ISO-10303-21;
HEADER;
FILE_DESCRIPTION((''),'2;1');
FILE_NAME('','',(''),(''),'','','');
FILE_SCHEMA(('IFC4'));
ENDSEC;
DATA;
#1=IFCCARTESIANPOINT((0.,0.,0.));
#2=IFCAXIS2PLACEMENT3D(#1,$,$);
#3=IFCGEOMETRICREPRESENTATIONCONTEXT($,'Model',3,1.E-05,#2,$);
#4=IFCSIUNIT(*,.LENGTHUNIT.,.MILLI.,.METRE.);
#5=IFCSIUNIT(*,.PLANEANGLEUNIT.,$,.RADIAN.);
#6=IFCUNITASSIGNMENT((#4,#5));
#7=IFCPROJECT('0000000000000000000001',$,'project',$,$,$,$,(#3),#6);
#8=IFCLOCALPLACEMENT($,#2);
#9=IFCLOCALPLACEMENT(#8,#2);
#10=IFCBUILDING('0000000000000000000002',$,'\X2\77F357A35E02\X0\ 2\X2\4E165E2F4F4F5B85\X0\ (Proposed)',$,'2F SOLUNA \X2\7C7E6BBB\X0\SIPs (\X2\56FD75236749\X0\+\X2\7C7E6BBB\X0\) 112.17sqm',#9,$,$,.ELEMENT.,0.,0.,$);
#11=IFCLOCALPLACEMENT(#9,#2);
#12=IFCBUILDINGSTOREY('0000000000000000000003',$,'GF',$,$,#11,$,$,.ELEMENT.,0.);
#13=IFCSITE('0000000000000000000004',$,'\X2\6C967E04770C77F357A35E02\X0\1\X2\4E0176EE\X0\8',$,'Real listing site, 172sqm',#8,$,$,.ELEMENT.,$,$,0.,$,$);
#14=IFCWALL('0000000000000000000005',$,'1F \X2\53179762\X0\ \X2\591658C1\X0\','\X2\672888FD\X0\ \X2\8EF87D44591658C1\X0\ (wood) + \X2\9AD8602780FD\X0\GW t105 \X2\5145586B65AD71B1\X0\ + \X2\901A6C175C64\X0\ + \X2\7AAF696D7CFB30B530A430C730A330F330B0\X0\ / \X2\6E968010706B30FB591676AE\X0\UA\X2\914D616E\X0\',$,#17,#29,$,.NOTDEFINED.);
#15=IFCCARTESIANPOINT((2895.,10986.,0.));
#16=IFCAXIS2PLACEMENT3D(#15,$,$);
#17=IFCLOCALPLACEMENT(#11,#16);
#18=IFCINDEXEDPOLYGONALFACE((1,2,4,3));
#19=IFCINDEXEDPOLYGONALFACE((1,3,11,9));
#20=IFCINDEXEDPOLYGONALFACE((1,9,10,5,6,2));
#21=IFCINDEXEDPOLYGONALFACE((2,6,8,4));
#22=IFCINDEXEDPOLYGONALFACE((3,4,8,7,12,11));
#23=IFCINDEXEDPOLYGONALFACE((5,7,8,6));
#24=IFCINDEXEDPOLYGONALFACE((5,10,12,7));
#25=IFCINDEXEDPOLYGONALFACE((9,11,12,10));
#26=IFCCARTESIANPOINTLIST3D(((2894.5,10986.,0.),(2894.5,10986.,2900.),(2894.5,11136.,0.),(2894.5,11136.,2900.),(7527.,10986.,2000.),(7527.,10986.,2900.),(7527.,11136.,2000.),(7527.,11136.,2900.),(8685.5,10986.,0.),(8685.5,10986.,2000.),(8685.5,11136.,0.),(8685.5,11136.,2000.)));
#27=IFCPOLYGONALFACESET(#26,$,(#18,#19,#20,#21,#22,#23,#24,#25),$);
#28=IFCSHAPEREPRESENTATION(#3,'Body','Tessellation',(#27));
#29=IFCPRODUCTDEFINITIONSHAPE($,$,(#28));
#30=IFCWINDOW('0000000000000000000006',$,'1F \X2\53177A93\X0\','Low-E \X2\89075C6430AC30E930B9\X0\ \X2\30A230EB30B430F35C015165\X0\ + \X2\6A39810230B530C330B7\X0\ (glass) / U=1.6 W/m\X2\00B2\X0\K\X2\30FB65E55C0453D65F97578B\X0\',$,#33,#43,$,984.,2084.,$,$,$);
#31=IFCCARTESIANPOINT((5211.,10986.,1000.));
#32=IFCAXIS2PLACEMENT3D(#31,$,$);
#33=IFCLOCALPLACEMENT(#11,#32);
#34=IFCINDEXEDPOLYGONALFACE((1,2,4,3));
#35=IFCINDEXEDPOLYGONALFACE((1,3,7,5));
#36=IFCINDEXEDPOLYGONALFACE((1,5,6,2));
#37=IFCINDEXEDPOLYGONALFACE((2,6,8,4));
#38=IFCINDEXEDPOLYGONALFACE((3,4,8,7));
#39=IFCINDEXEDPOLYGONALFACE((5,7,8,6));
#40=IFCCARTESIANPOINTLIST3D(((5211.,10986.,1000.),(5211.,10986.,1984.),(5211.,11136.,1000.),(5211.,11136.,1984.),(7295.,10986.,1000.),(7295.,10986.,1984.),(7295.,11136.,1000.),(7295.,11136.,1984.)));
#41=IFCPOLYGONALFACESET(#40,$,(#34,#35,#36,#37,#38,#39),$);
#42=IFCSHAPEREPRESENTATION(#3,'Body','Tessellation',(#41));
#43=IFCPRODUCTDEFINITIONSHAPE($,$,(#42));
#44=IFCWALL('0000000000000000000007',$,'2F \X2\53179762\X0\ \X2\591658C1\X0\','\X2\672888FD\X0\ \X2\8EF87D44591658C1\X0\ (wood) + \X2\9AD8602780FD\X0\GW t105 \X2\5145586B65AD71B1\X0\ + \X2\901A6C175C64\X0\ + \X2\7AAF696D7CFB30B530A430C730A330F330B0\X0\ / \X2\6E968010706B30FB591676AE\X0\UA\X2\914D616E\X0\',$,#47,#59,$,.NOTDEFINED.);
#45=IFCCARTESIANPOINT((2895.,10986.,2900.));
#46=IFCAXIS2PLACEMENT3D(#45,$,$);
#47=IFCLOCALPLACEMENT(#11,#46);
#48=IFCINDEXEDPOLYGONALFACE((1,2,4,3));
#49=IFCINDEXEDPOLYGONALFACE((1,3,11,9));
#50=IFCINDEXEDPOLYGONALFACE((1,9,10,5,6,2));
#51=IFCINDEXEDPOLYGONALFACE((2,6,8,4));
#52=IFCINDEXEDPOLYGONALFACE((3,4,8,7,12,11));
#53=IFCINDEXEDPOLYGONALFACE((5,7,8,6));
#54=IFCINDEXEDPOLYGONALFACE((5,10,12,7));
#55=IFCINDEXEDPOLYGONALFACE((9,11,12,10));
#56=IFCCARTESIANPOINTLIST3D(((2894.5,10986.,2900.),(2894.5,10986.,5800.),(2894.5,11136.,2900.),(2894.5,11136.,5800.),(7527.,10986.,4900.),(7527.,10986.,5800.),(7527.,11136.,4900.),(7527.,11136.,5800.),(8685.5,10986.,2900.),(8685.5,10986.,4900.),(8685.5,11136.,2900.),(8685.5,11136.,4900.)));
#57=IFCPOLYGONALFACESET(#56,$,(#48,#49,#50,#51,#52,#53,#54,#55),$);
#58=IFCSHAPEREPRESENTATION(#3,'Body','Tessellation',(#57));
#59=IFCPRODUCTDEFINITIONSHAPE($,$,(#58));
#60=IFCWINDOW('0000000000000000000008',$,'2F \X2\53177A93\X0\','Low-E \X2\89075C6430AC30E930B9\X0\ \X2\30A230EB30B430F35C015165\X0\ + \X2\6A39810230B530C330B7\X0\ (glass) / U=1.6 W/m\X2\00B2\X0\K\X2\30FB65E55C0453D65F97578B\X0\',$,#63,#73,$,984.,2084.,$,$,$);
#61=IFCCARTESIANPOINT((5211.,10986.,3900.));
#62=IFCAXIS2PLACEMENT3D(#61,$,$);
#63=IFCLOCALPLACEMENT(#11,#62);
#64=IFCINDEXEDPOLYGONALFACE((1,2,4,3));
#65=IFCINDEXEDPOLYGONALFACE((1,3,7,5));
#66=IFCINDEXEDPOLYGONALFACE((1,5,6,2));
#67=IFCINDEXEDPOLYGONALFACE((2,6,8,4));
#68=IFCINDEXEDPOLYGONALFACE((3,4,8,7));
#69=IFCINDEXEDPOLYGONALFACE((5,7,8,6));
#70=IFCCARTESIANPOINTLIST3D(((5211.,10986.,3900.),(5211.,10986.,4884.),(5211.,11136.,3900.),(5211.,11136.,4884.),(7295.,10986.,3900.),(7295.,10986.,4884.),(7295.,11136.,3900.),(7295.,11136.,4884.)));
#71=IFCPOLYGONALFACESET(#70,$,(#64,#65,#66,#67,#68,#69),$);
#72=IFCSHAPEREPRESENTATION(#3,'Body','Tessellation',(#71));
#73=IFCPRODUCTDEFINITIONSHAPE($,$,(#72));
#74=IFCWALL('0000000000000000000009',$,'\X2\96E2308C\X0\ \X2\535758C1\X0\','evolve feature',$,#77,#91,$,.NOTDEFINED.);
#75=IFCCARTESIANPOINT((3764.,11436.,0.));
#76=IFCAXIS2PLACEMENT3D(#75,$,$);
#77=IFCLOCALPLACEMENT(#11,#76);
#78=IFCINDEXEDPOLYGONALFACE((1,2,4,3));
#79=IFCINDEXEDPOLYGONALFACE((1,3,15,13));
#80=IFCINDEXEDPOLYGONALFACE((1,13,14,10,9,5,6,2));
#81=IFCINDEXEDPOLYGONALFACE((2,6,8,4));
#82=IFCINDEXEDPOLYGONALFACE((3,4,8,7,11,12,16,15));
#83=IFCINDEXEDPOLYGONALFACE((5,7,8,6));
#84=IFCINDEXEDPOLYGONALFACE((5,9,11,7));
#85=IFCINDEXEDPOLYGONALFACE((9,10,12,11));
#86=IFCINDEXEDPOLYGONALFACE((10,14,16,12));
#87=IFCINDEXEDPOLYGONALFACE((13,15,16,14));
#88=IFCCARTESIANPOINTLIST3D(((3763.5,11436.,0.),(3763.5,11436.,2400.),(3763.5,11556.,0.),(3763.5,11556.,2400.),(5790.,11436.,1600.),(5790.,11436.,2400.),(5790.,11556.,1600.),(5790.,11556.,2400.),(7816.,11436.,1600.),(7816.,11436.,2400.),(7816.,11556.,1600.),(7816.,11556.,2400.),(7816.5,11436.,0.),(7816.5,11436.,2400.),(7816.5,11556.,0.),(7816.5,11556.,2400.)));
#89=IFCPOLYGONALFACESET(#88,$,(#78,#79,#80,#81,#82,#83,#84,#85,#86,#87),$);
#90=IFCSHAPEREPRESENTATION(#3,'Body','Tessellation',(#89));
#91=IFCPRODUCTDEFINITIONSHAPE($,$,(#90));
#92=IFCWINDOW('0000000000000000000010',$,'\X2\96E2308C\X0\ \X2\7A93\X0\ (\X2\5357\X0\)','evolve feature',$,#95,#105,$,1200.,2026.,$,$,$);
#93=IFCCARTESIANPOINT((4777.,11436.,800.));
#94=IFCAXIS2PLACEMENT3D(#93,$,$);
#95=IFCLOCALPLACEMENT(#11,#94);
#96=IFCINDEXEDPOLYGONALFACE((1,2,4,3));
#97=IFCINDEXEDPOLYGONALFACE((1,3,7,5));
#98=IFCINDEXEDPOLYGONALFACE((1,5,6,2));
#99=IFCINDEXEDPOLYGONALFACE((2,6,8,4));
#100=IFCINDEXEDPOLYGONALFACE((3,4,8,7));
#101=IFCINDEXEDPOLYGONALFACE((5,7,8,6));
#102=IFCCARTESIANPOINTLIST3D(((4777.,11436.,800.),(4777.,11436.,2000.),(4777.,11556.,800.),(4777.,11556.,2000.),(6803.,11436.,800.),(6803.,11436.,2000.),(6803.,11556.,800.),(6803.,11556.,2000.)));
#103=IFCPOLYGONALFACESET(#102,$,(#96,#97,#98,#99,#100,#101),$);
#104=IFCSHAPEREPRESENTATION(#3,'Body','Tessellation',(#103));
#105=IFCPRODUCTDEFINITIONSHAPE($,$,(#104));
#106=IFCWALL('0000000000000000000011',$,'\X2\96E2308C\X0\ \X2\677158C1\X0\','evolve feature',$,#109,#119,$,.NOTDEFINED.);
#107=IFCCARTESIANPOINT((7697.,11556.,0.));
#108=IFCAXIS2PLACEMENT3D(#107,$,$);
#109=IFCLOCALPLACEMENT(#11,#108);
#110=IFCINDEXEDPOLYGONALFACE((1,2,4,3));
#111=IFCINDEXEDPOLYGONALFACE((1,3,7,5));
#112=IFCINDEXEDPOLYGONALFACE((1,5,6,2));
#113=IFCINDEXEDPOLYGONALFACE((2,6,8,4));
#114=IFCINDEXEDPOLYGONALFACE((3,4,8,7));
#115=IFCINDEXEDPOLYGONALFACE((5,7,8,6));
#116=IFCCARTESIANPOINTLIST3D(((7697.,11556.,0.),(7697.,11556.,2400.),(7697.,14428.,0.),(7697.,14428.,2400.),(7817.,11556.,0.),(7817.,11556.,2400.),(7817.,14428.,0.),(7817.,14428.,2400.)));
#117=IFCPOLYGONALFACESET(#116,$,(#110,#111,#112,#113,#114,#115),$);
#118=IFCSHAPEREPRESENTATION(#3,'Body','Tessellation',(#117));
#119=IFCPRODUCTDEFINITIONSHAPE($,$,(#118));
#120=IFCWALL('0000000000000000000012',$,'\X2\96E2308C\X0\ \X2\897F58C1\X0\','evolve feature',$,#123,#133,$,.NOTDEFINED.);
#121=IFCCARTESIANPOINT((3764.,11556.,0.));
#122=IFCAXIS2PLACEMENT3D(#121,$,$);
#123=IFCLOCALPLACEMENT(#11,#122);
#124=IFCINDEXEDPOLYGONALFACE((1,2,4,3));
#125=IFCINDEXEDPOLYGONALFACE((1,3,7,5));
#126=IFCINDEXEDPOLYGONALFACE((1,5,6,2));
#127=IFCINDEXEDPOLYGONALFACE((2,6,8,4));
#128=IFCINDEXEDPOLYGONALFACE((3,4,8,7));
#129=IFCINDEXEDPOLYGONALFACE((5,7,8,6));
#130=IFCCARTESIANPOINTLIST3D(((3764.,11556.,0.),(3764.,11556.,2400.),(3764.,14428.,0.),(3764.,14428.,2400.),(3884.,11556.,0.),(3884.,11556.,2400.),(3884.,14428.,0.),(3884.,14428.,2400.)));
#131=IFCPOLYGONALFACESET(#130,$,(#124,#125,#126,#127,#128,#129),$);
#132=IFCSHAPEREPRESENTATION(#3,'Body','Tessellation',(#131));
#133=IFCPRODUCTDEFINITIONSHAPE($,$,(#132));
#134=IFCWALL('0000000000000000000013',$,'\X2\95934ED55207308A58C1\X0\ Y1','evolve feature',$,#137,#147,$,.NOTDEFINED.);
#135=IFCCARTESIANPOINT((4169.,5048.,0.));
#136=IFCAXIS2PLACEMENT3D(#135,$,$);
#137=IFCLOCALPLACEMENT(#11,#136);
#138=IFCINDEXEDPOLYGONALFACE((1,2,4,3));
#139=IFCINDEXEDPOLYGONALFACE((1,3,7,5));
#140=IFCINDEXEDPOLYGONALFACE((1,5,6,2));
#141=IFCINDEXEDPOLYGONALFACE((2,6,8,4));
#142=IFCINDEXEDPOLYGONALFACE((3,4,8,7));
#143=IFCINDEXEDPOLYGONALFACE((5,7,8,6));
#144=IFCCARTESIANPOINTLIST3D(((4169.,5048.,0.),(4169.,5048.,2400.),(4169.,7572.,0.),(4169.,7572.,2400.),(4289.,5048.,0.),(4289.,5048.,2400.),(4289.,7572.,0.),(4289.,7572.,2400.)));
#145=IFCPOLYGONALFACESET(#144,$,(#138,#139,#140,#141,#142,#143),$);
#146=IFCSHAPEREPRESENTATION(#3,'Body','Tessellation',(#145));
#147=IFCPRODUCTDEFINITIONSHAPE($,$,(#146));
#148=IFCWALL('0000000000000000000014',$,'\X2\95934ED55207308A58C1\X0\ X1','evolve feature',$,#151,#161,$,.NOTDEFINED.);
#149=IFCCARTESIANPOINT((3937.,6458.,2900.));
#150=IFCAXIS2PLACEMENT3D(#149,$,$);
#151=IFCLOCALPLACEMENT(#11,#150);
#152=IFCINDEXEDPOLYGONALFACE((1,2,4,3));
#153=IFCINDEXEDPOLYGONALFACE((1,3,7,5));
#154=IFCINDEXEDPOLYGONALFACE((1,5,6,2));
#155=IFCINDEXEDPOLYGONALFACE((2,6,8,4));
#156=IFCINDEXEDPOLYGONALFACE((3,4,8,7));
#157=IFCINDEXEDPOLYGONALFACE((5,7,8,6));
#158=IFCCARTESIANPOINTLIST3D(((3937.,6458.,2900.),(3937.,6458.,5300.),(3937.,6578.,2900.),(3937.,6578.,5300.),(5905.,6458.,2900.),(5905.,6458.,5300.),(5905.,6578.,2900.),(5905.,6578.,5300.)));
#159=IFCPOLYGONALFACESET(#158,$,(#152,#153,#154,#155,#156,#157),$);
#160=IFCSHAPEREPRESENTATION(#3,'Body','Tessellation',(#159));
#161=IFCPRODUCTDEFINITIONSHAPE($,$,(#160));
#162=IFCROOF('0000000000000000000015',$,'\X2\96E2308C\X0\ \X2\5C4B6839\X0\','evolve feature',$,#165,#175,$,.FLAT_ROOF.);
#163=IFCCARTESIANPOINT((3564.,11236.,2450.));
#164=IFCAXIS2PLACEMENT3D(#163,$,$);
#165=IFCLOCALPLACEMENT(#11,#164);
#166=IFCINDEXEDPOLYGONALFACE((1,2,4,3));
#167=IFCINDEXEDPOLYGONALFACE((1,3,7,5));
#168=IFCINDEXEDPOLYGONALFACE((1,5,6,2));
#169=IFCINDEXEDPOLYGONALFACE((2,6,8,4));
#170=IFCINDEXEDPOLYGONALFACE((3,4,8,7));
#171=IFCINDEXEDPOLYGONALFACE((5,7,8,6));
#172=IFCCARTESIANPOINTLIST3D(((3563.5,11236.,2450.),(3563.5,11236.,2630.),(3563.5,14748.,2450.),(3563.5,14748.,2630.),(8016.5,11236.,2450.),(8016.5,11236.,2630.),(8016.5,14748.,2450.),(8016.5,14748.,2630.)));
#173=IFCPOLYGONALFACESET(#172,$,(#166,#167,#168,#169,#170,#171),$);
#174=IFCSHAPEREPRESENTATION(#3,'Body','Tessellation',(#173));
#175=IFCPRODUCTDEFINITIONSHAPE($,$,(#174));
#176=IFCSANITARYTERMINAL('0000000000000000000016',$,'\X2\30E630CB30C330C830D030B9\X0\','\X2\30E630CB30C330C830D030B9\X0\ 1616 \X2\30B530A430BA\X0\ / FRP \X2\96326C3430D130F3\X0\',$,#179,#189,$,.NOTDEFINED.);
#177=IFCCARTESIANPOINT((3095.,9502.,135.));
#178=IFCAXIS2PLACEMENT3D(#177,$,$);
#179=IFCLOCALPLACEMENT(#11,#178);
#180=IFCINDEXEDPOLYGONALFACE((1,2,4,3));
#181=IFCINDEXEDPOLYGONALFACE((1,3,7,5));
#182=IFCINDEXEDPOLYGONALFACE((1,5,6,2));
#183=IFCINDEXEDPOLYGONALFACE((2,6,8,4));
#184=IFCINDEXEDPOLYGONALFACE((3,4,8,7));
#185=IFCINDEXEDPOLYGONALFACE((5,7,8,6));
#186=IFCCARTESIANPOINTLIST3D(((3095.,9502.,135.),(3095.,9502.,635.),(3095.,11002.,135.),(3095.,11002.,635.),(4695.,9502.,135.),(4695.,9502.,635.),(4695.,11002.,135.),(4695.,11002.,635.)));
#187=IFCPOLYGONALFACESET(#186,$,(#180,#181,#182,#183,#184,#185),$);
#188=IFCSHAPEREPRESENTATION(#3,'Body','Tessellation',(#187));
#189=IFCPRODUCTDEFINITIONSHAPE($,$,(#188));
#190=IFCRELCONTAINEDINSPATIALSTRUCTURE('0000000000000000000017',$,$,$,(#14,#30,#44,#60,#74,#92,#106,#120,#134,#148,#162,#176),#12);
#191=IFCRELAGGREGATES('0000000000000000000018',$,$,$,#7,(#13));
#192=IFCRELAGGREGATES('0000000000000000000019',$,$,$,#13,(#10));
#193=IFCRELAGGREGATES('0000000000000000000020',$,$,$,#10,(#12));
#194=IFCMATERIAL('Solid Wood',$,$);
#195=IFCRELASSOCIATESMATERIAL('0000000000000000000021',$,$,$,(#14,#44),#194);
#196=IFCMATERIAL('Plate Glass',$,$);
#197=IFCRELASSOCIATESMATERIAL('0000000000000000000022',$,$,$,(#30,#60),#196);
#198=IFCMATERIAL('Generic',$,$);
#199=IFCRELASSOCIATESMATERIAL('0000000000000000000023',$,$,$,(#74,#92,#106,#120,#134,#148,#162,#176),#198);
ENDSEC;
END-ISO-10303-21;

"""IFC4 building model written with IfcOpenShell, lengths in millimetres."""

from ifc_helpers import new_model, si_unit, frame, frame_2d, origin, place, context, project, spatial, rectangle, extrude, material, element, fill, save


model = new_model("IFC4")

# Units and contexts
model_context = context("Model", 3, precision=1e-05, world=origin())
ifc_project = project(units=[si_unit("LENGTHUNIT", "METRE", prefix="MILLI"), si_unit("PLANEANGLEUNIT", "RADIAN")], contexts=[model_context])

# Site, building, storey
site_placement = place(None, origin())
site = spatial("IfcSite", under=ifc_project, at=site_placement, Name="沖縄県石垣市1丁目8", ObjectType="Real listing site, 172sqm", CompositionType="ELEMENT", RefElevation=0.0)
building_placement = place(site_placement, origin())
building = spatial("IfcBuilding", under=site, at=building_placement, Name="石垣市 2世帯住宅 (Proposed)", ObjectType="2F SOLUNA 籾殻SIPs (国産杉+籾殻) 112.17sqm", CompositionType="ELEMENT", ElevationOfRefHeight=0.0, ElevationOfTerrain=0.0)
storey_placement = place(building_placement, origin())
storey = spatial("IfcBuildingStorey", under=building, at=storey_placement, Name="GF", CompositionType="ELEMENT", Elevation=0.0)

# Shared definitions
ifc_material_1 = material(Name="Generic")

# Wall, opening, window
ifc_material_2 = material(Name="Solid Wood")
wall_1_placement = place(storey_placement, frame((2895.0, 10986.0, 0.0)))
wall_1 = element("IfcWall", 1, at=wall_1_placement, inside=storey, material=ifc_material_2, Name="1F 北面 外壁", Description="木製 軸組外壁 (wood) + 高性能GW t105 充填断熱 + 通気層 + 窯業系サイディング / 準耐火・外皮UA配慮", PredefinedType="NOTDEFINED", context=model_context, shape_type="SweptSolid", body=[
    extrude(rectangle(XDim=5791.0, YDim=150.0, at=frame_2d((2895.0, 75.0))), frame((2895.0, 10986.0, 0.0)), (0.0, 0.0, 1.0), 2900.0),
])
opening_1_placement = place(storey_placement, frame((5211.0, 10986.0, 1000.0)))
opening_1 = element("IfcOpeningElement", 2, at=opening_1_placement, cuts=wall_1, PredefinedType="NOTDEFINED", context=model_context, shape_type="SweptSolid", body=[
    extrude(rectangle(XDim=2084.0, YDim=150.0, at=frame_2d((1042.0, 75.0))), frame((5211.0, 10986.0, 1000.0)), (0.0, 0.0, 1.0), 984.0),
])
ifc_material_3 = material(Name="Plate Glass")
window_1_placement = place(storey_placement, frame((5211.0, 10986.0, 1000.0)))
window_1 = element("IfcWindow", 3, at=window_1_placement, inside=storey, material=ifc_material_3, Name="1F 北窓", Description="Low-E 複層ガラス アルゴン封入 + 樹脂サッシ (glass) / U=1.6 W/m²K・日射取得型", OverallHeight=984.0, OverallWidth=2084.0, context=model_context, shape_type="SweptSolid", body=[
    extrude(rectangle(XDim=2084.0, YDim=150.0, at=frame_2d((1042.0, 75.0))), frame((5211.0, 10986.0, 1000.0)), (0.0, 0.0, 1.0), 984.0),
])
fill(opening_1, window_1)

# Wall, opening, window
wall_2_placement = place(storey_placement, frame((2895.0, 10986.0, 2900.0)))
wall_2 = element("IfcWall", 4, at=wall_2_placement, inside=storey, material=ifc_material_2, Name="2F 北面 外壁", Description="木製 軸組外壁 (wood) + 高性能GW t105 充填断熱 + 通気層 + 窯業系サイディング / 準耐火・外皮UA配慮", PredefinedType="NOTDEFINED", context=model_context, shape_type="SweptSolid", body=[
    extrude(rectangle(XDim=5791.0, YDim=150.0, at=frame_2d((2895.0, 75.0))), frame((2895.0, 10986.0, 2900.0)), (0.0, 0.0, 1.0), 2900.0),
])
opening_2_placement = place(storey_placement, frame((5211.0, 10986.0, 3900.0)))
opening_2 = element("IfcOpeningElement", 5, at=opening_2_placement, cuts=wall_2, PredefinedType="NOTDEFINED", context=model_context, shape_type="SweptSolid", body=[
    extrude(rectangle(XDim=2084.0, YDim=150.0, at=frame_2d((1042.0, 75.0))), frame((5211.0, 10986.0, 3900.0)), (0.0, 0.0, 1.0), 984.0),
])
window_2_placement = place(storey_placement, frame((5211.0, 10986.0, 3900.0)))
window_2 = element("IfcWindow", 6, at=window_2_placement, inside=storey, material=ifc_material_3, Name="2F 北窓", Description="Low-E 複層ガラス アルゴン封入 + 樹脂サッシ (glass) / U=1.6 W/m²K・日射取得型", OverallHeight=984.0, OverallWidth=2084.0, context=model_context, shape_type="SweptSolid", body=[
    extrude(rectangle(XDim=2084.0, YDim=150.0, at=frame_2d((1042.0, 75.0))), frame((5211.0, 10986.0, 3900.0)), (0.0, 0.0, 1.0), 984.0),
])
fill(opening_2, window_2)

# Wall, opening, window
wall_3_placement = place(storey_placement, frame((3764.0, 11436.0, 0.0)))
wall_3 = element("IfcWall", 7, at=wall_3_placement, inside=storey, material=ifc_material_1, Name="離れ 南壁", Description="evolve feature", PredefinedType="NOTDEFINED", context=model_context, shape_type="SweptSolid", body=[
    extrude(rectangle(XDim=4053.0, YDim=120.0, at=frame_2d((2026.0, 60.0))), frame((3764.0, 11436.0, 0.0)), (0.0, 0.0, 1.0), 2400.0),
])
opening_3_placement = place(storey_placement, frame((4777.0, 11436.0, 800.0)))
opening_3 = element("IfcOpeningElement", 8, at=opening_3_placement, cuts=wall_3, PredefinedType="NOTDEFINED", context=model_context, shape_type="SweptSolid", body=[
    extrude(rectangle(XDim=2026.0, YDim=120.0, at=frame_2d((1013.0, 60.0))), frame((4777.0, 11436.0, 800.0)), (0.0, 0.0, 1.0), 1200.0),
])
window_3_placement = place(storey_placement, frame((4777.0, 11436.0, 800.0)))
window_3 = element("IfcWindow", 9, at=window_3_placement, inside=storey, material=ifc_material_1, Name="離れ 窓 (南)", Description="evolve feature", OverallHeight=1200.0, OverallWidth=2026.0, context=model_context, shape_type="SweptSolid", body=[
    extrude(rectangle(XDim=2026.0, YDim=120.0, at=frame_2d((1013.0, 60.0))), frame((4777.0, 11436.0, 800.0)), (0.0, 0.0, 1.0), 1200.0),
])
fill(opening_3, window_3)

# Walls
wall_4_placement = place(storey_placement, frame((7697.0, 11556.0, 0.0)))
element("IfcWall", 10, at=wall_4_placement, inside=storey, material=ifc_material_1, Name="離れ 東壁", Description="evolve feature", PredefinedType="NOTDEFINED", context=model_context, shape_type="SweptSolid", body=[
    extrude(rectangle(XDim=120.0, YDim=2872.0, at=frame_2d((60.0, 1436.0))), frame((7697.0, 11556.0, 0.0)), (0.0, 0.0, 1.0), 2400.0),
])
wall_5_placement = place(storey_placement, frame((3764.0, 11556.0, 0.0)))
element("IfcWall", 11, at=wall_5_placement, inside=storey, material=ifc_material_1, Name="離れ 西壁", Description="evolve feature", PredefinedType="NOTDEFINED", context=model_context, shape_type="SweptSolid", body=[
    extrude(rectangle(XDim=120.0, YDim=2872.0, at=frame_2d((60.0, 1436.0))), frame((3764.0, 11556.0, 0.0)), (0.0, 0.0, 1.0), 2400.0),
])
wall_6_placement = place(storey_placement, frame((4169.0, 5048.0, 0.0)))
element("IfcWall", 12, at=wall_6_placement, inside=storey, material=ifc_material_1, Name="間仕切り壁 Y1", Description="evolve feature", PredefinedType="NOTDEFINED", context=model_context, shape_type="SweptSolid", body=[
    extrude(rectangle(XDim=120.0, YDim=2524.0, at=frame_2d((60.0, 1262.0))), frame((4169.0, 5048.0, 0.0)), (0.0, 0.0, 1.0), 2400.0),
])
wall_7_placement = place(storey_placement, frame((3937.0, 6458.0, 2900.0)))
element("IfcWall", 13, at=wall_7_placement, inside=storey, material=ifc_material_1, Name="間仕切り壁 X1", Description="evolve feature", PredefinedType="NOTDEFINED", context=model_context, shape_type="SweptSolid", body=[
    extrude(rectangle(XDim=1968.0, YDim=120.0, at=frame_2d((984.0, 60.0))), frame((3937.0, 6458.0, 2900.0)), (0.0, 0.0, 1.0), 2400.0),
])

# Roof
roof_placement = place(storey_placement, frame((3564.0, 11236.0, 2450.0)))
element("IfcRoof", 14, at=roof_placement, inside=storey, material=ifc_material_1, Name="離れ 屋根", Description="evolve feature", PredefinedType="FLAT_ROOF", context=model_context, shape_type="SweptSolid", body=[
    extrude(rectangle(XDim=4453.0, YDim=3512.0, at=frame_2d((2226.0, 1756.0))), frame((3564.0, 11236.0, 2450.0)), (0.0, 0.0, 1.0), 180.0),
])

# Sanitary terminal
sanitary_terminal_1_placement = place(storey_placement, frame((3095.0, 9502.0, 135.0)))
element("IfcSanitaryTerminal", 15, at=sanitary_terminal_1_placement, inside=storey, material=ifc_material_1, Name="ユニットバス", Description="ユニットバス 1616 サイズ / FRP 防水パン", PredefinedType="NOTDEFINED", context=model_context, shape_type="SweptSolid", body=[
    extrude(rectangle(XDim=1600.0, YDim=1500.0, at=frame_2d((800.0, 750.0))), frame((3095.0, 9502.0, 135.0)), (0.0, 0.0, 1.0), 500.0),
])

save(model, "model.ifc")
